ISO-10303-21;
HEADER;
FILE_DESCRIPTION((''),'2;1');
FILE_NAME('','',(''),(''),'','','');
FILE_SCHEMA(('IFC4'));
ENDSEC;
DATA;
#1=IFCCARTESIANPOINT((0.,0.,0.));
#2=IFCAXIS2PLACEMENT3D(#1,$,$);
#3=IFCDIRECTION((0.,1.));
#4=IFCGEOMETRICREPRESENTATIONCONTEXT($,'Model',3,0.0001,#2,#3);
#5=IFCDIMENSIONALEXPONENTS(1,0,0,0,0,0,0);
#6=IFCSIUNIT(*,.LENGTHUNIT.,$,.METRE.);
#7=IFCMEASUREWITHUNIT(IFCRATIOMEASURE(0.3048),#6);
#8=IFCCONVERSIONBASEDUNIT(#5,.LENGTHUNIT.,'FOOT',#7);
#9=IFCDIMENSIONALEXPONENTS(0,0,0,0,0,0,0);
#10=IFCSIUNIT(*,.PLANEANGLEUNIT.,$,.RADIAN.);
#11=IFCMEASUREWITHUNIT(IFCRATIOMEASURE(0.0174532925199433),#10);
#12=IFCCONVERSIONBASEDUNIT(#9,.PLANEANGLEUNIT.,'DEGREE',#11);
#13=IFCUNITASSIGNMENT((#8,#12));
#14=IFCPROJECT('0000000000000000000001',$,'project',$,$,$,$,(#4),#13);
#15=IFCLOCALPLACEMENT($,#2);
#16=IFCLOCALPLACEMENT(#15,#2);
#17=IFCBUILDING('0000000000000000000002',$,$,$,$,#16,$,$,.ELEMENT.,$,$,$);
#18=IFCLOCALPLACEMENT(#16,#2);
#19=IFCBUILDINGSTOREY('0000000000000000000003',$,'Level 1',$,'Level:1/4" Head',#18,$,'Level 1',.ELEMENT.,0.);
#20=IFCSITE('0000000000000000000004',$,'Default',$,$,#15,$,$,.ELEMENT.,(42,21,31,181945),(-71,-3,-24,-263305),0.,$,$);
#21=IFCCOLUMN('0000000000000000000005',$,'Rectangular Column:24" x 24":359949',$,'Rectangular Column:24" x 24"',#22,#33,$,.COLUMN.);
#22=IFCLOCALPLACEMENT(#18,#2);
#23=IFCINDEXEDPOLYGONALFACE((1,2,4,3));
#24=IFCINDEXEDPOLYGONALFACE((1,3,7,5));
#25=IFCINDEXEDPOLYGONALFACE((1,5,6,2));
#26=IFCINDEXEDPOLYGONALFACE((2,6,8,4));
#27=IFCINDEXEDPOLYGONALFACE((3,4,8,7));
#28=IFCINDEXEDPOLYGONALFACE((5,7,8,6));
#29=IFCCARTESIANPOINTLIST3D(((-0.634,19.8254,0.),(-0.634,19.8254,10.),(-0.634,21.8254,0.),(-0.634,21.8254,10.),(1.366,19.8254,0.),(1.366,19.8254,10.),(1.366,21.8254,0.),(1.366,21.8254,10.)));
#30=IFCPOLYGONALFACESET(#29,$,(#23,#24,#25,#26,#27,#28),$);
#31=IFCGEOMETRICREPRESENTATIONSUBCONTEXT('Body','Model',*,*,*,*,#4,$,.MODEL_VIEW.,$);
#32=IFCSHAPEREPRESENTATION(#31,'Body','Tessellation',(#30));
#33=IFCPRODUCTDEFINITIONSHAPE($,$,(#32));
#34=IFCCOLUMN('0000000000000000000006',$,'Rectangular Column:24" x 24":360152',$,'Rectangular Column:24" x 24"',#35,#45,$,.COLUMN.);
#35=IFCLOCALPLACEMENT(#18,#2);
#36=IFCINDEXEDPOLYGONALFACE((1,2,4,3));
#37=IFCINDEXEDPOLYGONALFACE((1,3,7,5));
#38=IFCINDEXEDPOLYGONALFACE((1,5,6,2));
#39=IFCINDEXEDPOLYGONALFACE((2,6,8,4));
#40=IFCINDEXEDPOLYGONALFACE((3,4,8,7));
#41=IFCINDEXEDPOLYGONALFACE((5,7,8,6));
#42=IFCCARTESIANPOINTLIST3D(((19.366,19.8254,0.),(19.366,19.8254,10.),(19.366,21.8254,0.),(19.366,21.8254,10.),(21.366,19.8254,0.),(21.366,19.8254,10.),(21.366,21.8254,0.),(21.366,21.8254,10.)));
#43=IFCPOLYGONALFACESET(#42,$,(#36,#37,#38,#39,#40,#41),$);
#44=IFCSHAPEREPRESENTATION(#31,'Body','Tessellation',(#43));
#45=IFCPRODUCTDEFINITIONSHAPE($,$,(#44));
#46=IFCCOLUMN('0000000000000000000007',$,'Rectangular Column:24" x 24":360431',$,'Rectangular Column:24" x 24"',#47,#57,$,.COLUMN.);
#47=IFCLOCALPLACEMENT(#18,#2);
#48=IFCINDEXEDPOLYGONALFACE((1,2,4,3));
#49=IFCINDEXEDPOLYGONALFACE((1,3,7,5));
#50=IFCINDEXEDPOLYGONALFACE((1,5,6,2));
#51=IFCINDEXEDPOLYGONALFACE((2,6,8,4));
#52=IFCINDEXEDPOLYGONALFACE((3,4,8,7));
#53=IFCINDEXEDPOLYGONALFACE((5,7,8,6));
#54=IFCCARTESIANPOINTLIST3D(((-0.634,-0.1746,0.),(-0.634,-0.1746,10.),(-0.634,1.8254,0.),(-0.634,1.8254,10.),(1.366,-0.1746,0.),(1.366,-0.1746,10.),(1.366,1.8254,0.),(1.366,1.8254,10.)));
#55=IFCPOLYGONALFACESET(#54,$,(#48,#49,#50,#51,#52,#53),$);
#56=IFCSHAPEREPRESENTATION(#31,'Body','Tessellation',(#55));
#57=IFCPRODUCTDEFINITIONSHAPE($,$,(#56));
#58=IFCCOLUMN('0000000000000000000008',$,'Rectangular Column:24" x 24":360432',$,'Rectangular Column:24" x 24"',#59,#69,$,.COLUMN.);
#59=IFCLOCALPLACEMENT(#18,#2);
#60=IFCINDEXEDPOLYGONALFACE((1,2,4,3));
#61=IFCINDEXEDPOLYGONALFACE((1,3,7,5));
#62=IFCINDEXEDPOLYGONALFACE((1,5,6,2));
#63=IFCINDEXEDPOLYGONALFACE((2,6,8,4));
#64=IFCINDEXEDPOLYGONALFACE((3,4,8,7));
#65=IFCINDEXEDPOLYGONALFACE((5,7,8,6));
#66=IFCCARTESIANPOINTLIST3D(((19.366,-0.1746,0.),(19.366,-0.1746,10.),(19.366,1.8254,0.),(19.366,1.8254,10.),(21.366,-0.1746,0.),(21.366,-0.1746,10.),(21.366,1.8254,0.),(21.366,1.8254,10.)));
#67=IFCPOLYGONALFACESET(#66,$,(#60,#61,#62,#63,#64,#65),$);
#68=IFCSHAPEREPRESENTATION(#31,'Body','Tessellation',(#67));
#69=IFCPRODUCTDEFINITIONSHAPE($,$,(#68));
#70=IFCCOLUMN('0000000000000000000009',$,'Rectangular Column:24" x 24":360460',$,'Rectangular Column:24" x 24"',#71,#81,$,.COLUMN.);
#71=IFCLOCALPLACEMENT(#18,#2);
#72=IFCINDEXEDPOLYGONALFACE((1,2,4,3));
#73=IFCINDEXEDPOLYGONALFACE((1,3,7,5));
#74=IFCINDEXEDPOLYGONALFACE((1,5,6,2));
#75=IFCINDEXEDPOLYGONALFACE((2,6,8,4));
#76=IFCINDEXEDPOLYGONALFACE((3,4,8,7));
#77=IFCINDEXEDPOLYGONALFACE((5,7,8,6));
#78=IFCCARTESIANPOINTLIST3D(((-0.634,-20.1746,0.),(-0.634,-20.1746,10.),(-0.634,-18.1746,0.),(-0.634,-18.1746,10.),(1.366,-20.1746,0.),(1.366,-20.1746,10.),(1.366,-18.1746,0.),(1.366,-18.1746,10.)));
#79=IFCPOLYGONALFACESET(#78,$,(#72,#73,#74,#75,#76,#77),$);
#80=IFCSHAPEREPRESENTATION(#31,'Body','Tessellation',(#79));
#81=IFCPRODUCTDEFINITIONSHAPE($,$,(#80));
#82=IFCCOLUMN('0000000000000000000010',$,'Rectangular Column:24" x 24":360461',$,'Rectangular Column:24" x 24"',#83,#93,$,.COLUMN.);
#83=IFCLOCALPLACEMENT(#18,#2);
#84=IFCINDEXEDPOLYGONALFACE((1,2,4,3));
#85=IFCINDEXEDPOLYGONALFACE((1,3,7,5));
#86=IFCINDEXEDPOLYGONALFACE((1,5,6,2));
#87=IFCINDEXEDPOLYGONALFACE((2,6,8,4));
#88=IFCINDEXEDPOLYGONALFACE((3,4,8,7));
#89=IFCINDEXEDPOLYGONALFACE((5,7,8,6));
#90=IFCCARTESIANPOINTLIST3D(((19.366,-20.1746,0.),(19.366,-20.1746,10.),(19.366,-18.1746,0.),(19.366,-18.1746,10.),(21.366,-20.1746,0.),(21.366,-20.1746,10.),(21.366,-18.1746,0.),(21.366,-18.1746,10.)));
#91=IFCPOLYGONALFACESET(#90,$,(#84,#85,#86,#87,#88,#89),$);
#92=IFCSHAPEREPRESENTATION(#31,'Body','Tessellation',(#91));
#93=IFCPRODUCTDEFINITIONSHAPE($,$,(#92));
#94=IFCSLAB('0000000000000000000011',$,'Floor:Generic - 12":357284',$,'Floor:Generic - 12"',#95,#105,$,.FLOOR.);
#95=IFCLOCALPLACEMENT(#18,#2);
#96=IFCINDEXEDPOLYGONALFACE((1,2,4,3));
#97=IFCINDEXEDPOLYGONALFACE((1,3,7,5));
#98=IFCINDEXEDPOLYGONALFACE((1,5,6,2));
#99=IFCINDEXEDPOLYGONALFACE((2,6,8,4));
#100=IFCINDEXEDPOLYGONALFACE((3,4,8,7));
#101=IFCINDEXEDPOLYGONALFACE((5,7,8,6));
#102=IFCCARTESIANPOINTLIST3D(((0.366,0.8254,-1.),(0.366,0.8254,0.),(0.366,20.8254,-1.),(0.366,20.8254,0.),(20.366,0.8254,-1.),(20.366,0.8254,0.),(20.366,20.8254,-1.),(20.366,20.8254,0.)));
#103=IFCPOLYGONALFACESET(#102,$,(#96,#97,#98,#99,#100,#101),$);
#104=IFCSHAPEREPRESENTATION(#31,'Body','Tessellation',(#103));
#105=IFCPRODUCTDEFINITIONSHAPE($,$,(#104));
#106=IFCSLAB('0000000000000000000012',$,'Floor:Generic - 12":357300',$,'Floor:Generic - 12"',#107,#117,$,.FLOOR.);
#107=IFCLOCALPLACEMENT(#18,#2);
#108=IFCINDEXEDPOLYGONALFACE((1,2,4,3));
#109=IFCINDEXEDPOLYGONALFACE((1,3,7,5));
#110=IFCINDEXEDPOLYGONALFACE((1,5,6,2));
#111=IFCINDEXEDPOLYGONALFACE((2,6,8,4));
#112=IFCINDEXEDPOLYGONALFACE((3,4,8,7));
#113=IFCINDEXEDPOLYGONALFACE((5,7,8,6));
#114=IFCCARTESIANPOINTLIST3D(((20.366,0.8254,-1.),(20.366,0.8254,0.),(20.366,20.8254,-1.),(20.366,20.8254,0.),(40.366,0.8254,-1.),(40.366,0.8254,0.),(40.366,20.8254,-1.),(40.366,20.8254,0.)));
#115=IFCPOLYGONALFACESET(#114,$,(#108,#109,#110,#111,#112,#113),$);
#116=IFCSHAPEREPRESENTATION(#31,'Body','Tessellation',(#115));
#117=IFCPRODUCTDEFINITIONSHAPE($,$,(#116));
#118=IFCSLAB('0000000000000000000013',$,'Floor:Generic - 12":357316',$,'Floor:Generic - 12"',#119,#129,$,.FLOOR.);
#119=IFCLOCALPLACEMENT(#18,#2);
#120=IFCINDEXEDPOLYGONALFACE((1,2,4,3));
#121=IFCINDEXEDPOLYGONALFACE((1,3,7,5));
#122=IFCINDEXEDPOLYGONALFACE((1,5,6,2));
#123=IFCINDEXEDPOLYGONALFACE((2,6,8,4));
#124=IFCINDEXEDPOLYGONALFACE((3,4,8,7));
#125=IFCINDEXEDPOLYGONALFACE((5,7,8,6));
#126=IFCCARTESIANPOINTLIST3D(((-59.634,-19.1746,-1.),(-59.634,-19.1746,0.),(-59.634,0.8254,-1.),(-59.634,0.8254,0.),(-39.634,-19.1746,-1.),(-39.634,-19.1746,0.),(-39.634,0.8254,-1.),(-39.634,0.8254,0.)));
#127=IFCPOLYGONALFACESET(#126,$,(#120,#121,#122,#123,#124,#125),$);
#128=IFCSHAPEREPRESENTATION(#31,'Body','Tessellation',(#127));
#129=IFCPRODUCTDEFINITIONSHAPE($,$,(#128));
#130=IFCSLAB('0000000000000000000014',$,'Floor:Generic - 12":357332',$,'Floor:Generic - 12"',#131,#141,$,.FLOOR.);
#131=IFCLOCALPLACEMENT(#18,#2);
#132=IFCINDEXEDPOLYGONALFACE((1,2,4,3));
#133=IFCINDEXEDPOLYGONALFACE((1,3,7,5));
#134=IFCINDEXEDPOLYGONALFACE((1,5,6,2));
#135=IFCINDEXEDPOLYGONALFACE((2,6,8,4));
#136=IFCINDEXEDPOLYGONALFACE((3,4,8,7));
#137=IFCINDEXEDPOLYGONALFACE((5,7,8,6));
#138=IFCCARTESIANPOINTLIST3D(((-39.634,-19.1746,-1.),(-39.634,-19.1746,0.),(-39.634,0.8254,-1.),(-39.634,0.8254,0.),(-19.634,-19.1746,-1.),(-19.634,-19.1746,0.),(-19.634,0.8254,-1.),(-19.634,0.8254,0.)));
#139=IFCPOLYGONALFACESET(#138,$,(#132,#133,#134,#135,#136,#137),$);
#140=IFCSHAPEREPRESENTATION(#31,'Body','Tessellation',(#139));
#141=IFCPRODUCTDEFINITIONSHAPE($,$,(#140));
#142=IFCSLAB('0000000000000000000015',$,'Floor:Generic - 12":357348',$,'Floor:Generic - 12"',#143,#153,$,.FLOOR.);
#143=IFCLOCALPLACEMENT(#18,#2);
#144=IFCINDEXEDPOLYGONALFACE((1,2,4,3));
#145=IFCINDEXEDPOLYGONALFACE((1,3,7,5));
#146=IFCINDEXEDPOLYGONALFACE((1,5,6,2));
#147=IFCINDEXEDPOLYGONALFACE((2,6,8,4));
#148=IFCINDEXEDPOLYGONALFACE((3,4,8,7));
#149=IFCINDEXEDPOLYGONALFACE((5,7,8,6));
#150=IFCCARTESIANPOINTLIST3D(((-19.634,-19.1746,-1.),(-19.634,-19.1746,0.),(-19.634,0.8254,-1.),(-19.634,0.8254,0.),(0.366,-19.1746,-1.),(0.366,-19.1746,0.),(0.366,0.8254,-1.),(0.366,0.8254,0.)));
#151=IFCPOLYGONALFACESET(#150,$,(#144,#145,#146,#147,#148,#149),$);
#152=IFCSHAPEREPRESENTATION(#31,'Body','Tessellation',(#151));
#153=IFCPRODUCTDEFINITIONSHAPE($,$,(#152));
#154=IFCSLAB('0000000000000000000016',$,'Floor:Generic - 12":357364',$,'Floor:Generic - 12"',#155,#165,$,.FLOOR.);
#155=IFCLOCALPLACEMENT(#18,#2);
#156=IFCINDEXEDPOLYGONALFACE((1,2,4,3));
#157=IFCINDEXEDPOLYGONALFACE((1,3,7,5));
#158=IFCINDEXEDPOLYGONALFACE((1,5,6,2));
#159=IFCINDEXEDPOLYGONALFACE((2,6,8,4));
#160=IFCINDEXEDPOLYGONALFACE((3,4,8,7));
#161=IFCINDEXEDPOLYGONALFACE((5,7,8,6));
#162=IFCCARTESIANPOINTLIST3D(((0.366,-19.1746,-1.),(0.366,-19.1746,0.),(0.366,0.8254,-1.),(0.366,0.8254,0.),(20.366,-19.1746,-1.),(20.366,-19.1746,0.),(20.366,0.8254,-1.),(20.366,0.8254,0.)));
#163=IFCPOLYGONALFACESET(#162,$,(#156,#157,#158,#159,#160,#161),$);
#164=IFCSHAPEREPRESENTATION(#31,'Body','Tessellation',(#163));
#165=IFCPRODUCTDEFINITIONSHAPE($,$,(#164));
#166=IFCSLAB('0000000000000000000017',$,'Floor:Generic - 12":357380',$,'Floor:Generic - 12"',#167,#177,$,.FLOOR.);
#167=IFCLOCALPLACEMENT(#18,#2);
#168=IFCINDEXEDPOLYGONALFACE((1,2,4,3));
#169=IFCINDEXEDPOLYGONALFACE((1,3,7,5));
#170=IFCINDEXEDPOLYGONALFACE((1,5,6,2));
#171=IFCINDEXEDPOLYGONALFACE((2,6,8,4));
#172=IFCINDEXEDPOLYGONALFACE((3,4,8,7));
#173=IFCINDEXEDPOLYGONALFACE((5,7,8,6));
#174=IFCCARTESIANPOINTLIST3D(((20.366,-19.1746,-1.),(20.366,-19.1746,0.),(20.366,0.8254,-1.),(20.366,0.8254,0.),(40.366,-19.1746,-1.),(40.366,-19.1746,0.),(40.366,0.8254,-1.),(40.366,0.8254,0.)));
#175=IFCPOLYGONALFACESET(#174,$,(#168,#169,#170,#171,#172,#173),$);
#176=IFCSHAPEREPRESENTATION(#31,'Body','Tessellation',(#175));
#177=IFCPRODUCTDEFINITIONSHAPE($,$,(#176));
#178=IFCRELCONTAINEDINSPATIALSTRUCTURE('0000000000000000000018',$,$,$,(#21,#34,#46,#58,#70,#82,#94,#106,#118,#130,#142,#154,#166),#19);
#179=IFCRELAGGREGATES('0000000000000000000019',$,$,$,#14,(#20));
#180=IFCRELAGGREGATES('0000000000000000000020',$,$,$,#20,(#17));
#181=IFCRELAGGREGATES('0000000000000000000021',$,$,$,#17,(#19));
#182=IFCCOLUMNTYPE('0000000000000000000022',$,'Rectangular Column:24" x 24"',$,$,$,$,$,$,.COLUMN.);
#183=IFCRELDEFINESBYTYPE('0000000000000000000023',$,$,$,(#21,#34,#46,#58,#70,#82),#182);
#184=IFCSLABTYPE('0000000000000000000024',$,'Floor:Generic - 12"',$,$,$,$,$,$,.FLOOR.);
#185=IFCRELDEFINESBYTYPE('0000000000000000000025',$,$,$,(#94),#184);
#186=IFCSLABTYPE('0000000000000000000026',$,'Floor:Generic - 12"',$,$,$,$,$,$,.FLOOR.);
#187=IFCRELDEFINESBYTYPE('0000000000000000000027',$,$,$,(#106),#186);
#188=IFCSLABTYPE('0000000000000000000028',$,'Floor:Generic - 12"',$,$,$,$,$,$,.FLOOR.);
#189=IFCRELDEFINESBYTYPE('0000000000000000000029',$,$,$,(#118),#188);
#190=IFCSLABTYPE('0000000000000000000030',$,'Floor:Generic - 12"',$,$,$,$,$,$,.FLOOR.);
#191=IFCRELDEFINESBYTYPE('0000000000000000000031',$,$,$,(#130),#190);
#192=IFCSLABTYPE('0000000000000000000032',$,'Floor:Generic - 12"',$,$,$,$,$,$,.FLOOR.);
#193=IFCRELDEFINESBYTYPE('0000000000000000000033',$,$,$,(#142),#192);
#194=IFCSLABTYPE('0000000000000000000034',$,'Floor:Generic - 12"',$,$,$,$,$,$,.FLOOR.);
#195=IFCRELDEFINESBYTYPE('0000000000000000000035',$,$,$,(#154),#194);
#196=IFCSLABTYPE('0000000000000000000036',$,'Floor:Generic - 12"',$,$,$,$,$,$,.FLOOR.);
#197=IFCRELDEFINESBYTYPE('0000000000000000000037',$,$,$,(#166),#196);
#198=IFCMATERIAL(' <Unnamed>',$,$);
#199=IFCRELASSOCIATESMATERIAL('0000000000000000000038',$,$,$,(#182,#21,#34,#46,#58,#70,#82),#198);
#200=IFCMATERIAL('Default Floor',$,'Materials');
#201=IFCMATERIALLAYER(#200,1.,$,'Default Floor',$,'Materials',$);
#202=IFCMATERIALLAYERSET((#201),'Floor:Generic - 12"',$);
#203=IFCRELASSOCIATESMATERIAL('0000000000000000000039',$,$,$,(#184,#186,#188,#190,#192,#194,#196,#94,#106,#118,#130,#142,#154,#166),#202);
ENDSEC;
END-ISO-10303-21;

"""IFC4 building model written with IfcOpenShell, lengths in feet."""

from ifc_helpers import new_model, entity, si_unit, converted_unit, direction, frame, frame_2d, origin, origin_2d_with_axis, place, context, subcontext, project, spatial, rectangle, extrude, source, transform, mapped, material, layer, layer_set, layer_usage, material_profile, profile_set, profile_usage, type_object, type_shapes, element, save


model = new_model("IFC4")

# Units and contexts
model_context = context("Model", 3, precision=0.0001, world=origin(), true_north=direction((0.0, 1.0)))
body_context = subcontext(model_context, "Body", "Model", "MODEL_VIEW")
ifc_project = project(units=[converted_unit("LENGTHUNIT", "FOOT", entity("IfcRatioMeasure", 0.3048), si_unit("LENGTHUNIT", "METRE"), dimensions=[1, 0, 0, 0, 0, 0, 0]), converted_unit("PLANEANGLEUNIT", "DEGREE", entity("IfcRatioMeasure", 0.0174532925199433), si_unit("PLANEANGLEUNIT", "RADIAN"), dimensions=[0, 0, 0, 0, 0, 0, 0])], contexts=[model_context])

# Site, building, storey
site_placement = place(None, origin())
site = spatial("IfcSite", under=ifc_project, at=site_placement, Name="Default", CompositionType="ELEMENT", RefLatitude=(42, 21, 31, 181945), RefLongitude=(-71, -3, -24, -263305), RefElevation=0.0)
building_placement = place(site_placement, origin())
building = spatial("IfcBuilding", under=site, at=building_placement, CompositionType="ELEMENT")
storey_placement = place(building_placement, origin())
storey = spatial("IfcBuildingStorey", under=building, at=storey_placement, Name="Level 1", ObjectType="Level:1/4\" Head", LongName="Level 1", CompositionType="ELEMENT", Elevation=0.0)

# Columns
ifc_material_1 = material(Name=" <Unnamed>")
ifc_material_profile = material_profile(ifc_material_1, rectangle(XDim=2.0, YDim=2.0, at=origin_2d_with_axis()), Name="24\" x 24\"")
ifc_profile_set = profile_set([ifc_material_profile], Name="24\" x 24\"")
ifc_profile_usage_1 = profile_usage(ifc_profile_set)
column_type = type_object("IfcColumnType", Name="Rectangular Column:24\" x 24\"", PredefinedType="COLUMN", material=ifc_profile_set)
shared_shape = source(origin(), body_context, "Body", "SweptSolid", [
    extrude(rectangle(XDim=2.0, YDim=2.0, at=origin_2d_with_axis()), frame((0.0, 0.0, 0.0), z_axis=(0.0, 0.0, 1.0), x_axis=(0.0, -1.0, 0.0)), (0.0, 0.0, 1.0), 10.0),
])
type_shapes(column_type, [shared_shape])
column_1_placement = place(storey_placement, frame((0.366, 20.8254, 0.0)))
element("IfcColumn", 1, at=column_1_placement, inside=storey, type_object=column_type, material=ifc_profile_usage_1, Name="Rectangular Column:24\" x 24\":359949", ObjectType="Rectangular Column:24\" x 24\"", PredefinedType="COLUMN", context=body_context, shape_type="MappedRepresentation", body=[
    mapped(shared_shape, transform((0.0, 0.0, 0.0), scale=1.0)),
])
ifc_profile_usage_2 = profile_usage(ifc_profile_set)
column_2_placement = place(storey_placement, frame((20.366, 20.8254, 0.0)))
element("IfcColumn", 2, at=column_2_placement, inside=storey, type_object=column_type, material=ifc_profile_usage_2, Name="Rectangular Column:24\" x 24\":360152", ObjectType="Rectangular Column:24\" x 24\"", PredefinedType="COLUMN", context=body_context, shape_type="MappedRepresentation", body=[
    mapped(shared_shape, transform((0.0, 0.0, 0.0), scale=1.0)),
])
ifc_profile_usage_3 = profile_usage(ifc_profile_set)
column_3_placement = place(storey_placement, frame((0.366, 0.8254, 0.0)))
element("IfcColumn", 3, at=column_3_placement, inside=storey, type_object=column_type, material=ifc_profile_usage_3, Name="Rectangular Column:24\" x 24\":360431", ObjectType="Rectangular Column:24\" x 24\"", PredefinedType="COLUMN", context=body_context, shape_type="MappedRepresentation", body=[
    mapped(shared_shape, transform((0.0, 0.0, 0.0), scale=1.0)),
])
ifc_profile_usage_4 = profile_usage(ifc_profile_set)
column_4_placement = place(storey_placement, frame((20.366, 0.8254, 0.0)))
element("IfcColumn", 4, at=column_4_placement, inside=storey, type_object=column_type, material=ifc_profile_usage_4, Name="Rectangular Column:24\" x 24\":360432", ObjectType="Rectangular Column:24\" x 24\"", PredefinedType="COLUMN", context=body_context, shape_type="MappedRepresentation", body=[
    mapped(shared_shape, transform((0.0, 0.0, 0.0), scale=1.0)),
])
ifc_profile_usage_5 = profile_usage(ifc_profile_set)
column_5_placement = place(storey_placement, frame((0.366, -19.1746, 0.0)))
element("IfcColumn", 5, at=column_5_placement, inside=storey, type_object=column_type, material=ifc_profile_usage_5, Name="Rectangular Column:24\" x 24\":360460", ObjectType="Rectangular Column:24\" x 24\"", PredefinedType="COLUMN", context=body_context, shape_type="MappedRepresentation", body=[
    mapped(shared_shape, transform((0.0, 0.0, 0.0), scale=1.0)),
])
ifc_profile_usage_6 = profile_usage(ifc_profile_set)
column_6_placement = place(storey_placement, frame((20.366, -19.1746, 0.0)))
element("IfcColumn", 6, at=column_6_placement, inside=storey, type_object=column_type, material=ifc_profile_usage_6, Name="Rectangular Column:24\" x 24\":360461", ObjectType="Rectangular Column:24\" x 24\"", PredefinedType="COLUMN", context=body_context, shape_type="MappedRepresentation", body=[
    mapped(shared_shape, transform((0.0, 0.0, 0.0), scale=1.0)),
])

# Slabs
ifc_material_2 = material(Name="Default Floor", Category="Materials")
ifc_layer_1 = layer(ifc_material_2, 1.0, Name="Default Floor", Category="Materials")
ifc_layer_set_1 = layer_set([ifc_layer_1], Name="Floor:Generic - 12\"")
ifc_layer_usage_1 = layer_usage(ifc_layer_set_1, "AXIS3", "POSITIVE", 0.0)
slab_type_1 = type_object("IfcSlabType", Name="Floor:Generic - 12\"", PredefinedType="FLOOR", material=ifc_layer_set_1)
slab_1_placement = place(storey_placement, origin())
element("IfcSlab", 7, at=slab_1_placement, inside=storey, type_object=slab_type_1, material=ifc_layer_usage_1, Name="Floor:Generic - 12\":357284", ObjectType="Floor:Generic - 12\"", PredefinedType="FLOOR", context=body_context, shape_type="SweptSolid", body=[
    extrude(rectangle(XDim=20.0, YDim=20.0, at=origin_2d_with_axis()), frame((10.366, 10.8254, 0.0), z_axis=(0.0, 0.0, -1.0), x_axis=(0.0, 1.0, 0.0)), (0.0, 0.0, 1.0), 1.0),
])
ifc_layer_usage_2 = layer_usage(ifc_layer_set_1, "AXIS3", "POSITIVE", 0.0)
slab_type_2 = type_object("IfcSlabType", Name="Floor:Generic - 12\"", PredefinedType="FLOOR", material=ifc_layer_set_1)
slab_2_placement = place(storey_placement, origin())
element("IfcSlab", 8, at=slab_2_placement, inside=storey, type_object=slab_type_2, material=ifc_layer_usage_2, Name="Floor:Generic - 12\":357300", ObjectType="Floor:Generic - 12\"", PredefinedType="FLOOR", context=body_context, shape_type="SweptSolid", body=[
    extrude(rectangle(XDim=20.0, YDim=20.0, at=origin_2d_with_axis()), frame((30.366, 10.8254, 0.0), z_axis=(0.0, 0.0, -1.0), x_axis=(0.0, 1.0, 0.0)), (0.0, 0.0, 1.0), 1.0),
])
ifc_layer_usage_3 = layer_usage(ifc_layer_set_1, "AXIS3", "POSITIVE", 0.0)
slab_type_3 = type_object("IfcSlabType", Name="Floor:Generic - 12\"", PredefinedType="FLOOR", material=ifc_layer_set_1)
slab_3_placement = place(storey_placement, origin())
element("IfcSlab", 9, at=slab_3_placement, inside=storey, type_object=slab_type_3, material=ifc_layer_usage_3, Name="Floor:Generic - 12\":357316", ObjectType="Floor:Generic - 12\"", PredefinedType="FLOOR", context=body_context, shape_type="SweptSolid", body=[
    extrude(rectangle(XDim=20.0, YDim=20.0, at=frame_2d((0.0, 0.0), x_axis=(1.0, 0.0))), frame((-49.634, -9.1746, 0.0), z_axis=(0.0, 0.0, -1.0), x_axis=(0.0, 1.0, 0.0)), (0.0, 0.0, 1.0), 1.0),
])
ifc_layer_usage_4 = layer_usage(ifc_layer_set_1, "AXIS3", "POSITIVE", 0.0)
slab_type_4 = type_object("IfcSlabType", Name="Floor:Generic - 12\"", PredefinedType="FLOOR", material=ifc_layer_set_1)
slab_4_placement = place(storey_placement, origin())
element("IfcSlab", 10, at=slab_4_placement, inside=storey, type_object=slab_type_4, material=ifc_layer_usage_4, Name="Floor:Generic - 12\":357332", ObjectType="Floor:Generic - 12\"", PredefinedType="FLOOR", context=body_context, shape_type="SweptSolid", body=[
    extrude(rectangle(XDim=20.0, YDim=20.0, at=frame_2d((0.0, 0.0), x_axis=(1.0, 0.0))), frame((-29.634, -9.1746, 0.0), z_axis=(0.0, 0.0, -1.0), x_axis=(0.0, 1.0, 0.0)), (0.0, 0.0, 1.0), 1.0),
])
ifc_layer_usage_5 = layer_usage(ifc_layer_set_1, "AXIS3", "POSITIVE", 0.0)
slab_type_5 = type_object("IfcSlabType", Name="Floor:Generic - 12\"", PredefinedType="FLOOR", material=ifc_layer_set_1)
slab_5_placement = place(storey_placement, origin())
element("IfcSlab", 11, at=slab_5_placement, inside=storey, type_object=slab_type_5, material=ifc_layer_usage_5, Name="Floor:Generic - 12\":357348", ObjectType="Floor:Generic - 12\"", PredefinedType="FLOOR", context=body_context, shape_type="SweptSolid", body=[
    extrude(rectangle(XDim=20.0, YDim=20.0, at=origin_2d_with_axis()), frame((-9.634, -9.1746, 0.0), z_axis=(0.0, 0.0, -1.0), x_axis=(0.0, 1.0, 0.0)), (0.0, 0.0, 1.0), 1.0),
])
ifc_layer_usage_6 = layer_usage(ifc_layer_set_1, "AXIS3", "POSITIVE", 0.0)
slab_type_6 = type_object("IfcSlabType", Name="Floor:Generic - 12\"", PredefinedType="FLOOR", material=ifc_layer_set_1)
slab_6_placement = place(storey_placement, origin())
element("IfcSlab", 12, at=slab_6_placement, inside=storey, type_object=slab_type_6, material=ifc_layer_usage_6, Name="Floor:Generic - 12\":357364", ObjectType="Floor:Generic - 12\"", PredefinedType="FLOOR", context=body_context, shape_type="SweptSolid", body=[
    extrude(rectangle(XDim=20.0, YDim=20.0, at=origin_2d_with_axis()), frame((10.366, -9.1746, 0.0), z_axis=(0.0, 0.0, -1.0), x_axis=(0.0, 1.0, 0.0)), (0.0, 0.0, 1.0), 1.0),
])
ifc_layer_usage_7 = layer_usage(ifc_layer_set_1, "AXIS3", "POSITIVE", 0.0)
slab_type_7 = type_object("IfcSlabType", Name="Floor:Generic - 12\"", PredefinedType="FLOOR", material=ifc_layer_set_1)
slab_7_placement = place(storey_placement, origin())
element("IfcSlab", 13, at=slab_7_placement, inside=storey, type_object=slab_type_7, material=ifc_layer_usage_7, Name="Floor:Generic - 12\":357380", ObjectType="Floor:Generic - 12\"", PredefinedType="FLOOR", context=body_context, shape_type="SweptSolid", body=[
    extrude(rectangle(XDim=20.0, YDim=20.0, at=origin_2d_with_axis()), frame((30.366, -9.1746, 0.0), z_axis=(0.0, 0.0, -1.0), x_axis=(0.0, 1.0, 0.0)), (0.0, 0.0, 1.0), 1.0),
])

save(model, "model.ifc")
